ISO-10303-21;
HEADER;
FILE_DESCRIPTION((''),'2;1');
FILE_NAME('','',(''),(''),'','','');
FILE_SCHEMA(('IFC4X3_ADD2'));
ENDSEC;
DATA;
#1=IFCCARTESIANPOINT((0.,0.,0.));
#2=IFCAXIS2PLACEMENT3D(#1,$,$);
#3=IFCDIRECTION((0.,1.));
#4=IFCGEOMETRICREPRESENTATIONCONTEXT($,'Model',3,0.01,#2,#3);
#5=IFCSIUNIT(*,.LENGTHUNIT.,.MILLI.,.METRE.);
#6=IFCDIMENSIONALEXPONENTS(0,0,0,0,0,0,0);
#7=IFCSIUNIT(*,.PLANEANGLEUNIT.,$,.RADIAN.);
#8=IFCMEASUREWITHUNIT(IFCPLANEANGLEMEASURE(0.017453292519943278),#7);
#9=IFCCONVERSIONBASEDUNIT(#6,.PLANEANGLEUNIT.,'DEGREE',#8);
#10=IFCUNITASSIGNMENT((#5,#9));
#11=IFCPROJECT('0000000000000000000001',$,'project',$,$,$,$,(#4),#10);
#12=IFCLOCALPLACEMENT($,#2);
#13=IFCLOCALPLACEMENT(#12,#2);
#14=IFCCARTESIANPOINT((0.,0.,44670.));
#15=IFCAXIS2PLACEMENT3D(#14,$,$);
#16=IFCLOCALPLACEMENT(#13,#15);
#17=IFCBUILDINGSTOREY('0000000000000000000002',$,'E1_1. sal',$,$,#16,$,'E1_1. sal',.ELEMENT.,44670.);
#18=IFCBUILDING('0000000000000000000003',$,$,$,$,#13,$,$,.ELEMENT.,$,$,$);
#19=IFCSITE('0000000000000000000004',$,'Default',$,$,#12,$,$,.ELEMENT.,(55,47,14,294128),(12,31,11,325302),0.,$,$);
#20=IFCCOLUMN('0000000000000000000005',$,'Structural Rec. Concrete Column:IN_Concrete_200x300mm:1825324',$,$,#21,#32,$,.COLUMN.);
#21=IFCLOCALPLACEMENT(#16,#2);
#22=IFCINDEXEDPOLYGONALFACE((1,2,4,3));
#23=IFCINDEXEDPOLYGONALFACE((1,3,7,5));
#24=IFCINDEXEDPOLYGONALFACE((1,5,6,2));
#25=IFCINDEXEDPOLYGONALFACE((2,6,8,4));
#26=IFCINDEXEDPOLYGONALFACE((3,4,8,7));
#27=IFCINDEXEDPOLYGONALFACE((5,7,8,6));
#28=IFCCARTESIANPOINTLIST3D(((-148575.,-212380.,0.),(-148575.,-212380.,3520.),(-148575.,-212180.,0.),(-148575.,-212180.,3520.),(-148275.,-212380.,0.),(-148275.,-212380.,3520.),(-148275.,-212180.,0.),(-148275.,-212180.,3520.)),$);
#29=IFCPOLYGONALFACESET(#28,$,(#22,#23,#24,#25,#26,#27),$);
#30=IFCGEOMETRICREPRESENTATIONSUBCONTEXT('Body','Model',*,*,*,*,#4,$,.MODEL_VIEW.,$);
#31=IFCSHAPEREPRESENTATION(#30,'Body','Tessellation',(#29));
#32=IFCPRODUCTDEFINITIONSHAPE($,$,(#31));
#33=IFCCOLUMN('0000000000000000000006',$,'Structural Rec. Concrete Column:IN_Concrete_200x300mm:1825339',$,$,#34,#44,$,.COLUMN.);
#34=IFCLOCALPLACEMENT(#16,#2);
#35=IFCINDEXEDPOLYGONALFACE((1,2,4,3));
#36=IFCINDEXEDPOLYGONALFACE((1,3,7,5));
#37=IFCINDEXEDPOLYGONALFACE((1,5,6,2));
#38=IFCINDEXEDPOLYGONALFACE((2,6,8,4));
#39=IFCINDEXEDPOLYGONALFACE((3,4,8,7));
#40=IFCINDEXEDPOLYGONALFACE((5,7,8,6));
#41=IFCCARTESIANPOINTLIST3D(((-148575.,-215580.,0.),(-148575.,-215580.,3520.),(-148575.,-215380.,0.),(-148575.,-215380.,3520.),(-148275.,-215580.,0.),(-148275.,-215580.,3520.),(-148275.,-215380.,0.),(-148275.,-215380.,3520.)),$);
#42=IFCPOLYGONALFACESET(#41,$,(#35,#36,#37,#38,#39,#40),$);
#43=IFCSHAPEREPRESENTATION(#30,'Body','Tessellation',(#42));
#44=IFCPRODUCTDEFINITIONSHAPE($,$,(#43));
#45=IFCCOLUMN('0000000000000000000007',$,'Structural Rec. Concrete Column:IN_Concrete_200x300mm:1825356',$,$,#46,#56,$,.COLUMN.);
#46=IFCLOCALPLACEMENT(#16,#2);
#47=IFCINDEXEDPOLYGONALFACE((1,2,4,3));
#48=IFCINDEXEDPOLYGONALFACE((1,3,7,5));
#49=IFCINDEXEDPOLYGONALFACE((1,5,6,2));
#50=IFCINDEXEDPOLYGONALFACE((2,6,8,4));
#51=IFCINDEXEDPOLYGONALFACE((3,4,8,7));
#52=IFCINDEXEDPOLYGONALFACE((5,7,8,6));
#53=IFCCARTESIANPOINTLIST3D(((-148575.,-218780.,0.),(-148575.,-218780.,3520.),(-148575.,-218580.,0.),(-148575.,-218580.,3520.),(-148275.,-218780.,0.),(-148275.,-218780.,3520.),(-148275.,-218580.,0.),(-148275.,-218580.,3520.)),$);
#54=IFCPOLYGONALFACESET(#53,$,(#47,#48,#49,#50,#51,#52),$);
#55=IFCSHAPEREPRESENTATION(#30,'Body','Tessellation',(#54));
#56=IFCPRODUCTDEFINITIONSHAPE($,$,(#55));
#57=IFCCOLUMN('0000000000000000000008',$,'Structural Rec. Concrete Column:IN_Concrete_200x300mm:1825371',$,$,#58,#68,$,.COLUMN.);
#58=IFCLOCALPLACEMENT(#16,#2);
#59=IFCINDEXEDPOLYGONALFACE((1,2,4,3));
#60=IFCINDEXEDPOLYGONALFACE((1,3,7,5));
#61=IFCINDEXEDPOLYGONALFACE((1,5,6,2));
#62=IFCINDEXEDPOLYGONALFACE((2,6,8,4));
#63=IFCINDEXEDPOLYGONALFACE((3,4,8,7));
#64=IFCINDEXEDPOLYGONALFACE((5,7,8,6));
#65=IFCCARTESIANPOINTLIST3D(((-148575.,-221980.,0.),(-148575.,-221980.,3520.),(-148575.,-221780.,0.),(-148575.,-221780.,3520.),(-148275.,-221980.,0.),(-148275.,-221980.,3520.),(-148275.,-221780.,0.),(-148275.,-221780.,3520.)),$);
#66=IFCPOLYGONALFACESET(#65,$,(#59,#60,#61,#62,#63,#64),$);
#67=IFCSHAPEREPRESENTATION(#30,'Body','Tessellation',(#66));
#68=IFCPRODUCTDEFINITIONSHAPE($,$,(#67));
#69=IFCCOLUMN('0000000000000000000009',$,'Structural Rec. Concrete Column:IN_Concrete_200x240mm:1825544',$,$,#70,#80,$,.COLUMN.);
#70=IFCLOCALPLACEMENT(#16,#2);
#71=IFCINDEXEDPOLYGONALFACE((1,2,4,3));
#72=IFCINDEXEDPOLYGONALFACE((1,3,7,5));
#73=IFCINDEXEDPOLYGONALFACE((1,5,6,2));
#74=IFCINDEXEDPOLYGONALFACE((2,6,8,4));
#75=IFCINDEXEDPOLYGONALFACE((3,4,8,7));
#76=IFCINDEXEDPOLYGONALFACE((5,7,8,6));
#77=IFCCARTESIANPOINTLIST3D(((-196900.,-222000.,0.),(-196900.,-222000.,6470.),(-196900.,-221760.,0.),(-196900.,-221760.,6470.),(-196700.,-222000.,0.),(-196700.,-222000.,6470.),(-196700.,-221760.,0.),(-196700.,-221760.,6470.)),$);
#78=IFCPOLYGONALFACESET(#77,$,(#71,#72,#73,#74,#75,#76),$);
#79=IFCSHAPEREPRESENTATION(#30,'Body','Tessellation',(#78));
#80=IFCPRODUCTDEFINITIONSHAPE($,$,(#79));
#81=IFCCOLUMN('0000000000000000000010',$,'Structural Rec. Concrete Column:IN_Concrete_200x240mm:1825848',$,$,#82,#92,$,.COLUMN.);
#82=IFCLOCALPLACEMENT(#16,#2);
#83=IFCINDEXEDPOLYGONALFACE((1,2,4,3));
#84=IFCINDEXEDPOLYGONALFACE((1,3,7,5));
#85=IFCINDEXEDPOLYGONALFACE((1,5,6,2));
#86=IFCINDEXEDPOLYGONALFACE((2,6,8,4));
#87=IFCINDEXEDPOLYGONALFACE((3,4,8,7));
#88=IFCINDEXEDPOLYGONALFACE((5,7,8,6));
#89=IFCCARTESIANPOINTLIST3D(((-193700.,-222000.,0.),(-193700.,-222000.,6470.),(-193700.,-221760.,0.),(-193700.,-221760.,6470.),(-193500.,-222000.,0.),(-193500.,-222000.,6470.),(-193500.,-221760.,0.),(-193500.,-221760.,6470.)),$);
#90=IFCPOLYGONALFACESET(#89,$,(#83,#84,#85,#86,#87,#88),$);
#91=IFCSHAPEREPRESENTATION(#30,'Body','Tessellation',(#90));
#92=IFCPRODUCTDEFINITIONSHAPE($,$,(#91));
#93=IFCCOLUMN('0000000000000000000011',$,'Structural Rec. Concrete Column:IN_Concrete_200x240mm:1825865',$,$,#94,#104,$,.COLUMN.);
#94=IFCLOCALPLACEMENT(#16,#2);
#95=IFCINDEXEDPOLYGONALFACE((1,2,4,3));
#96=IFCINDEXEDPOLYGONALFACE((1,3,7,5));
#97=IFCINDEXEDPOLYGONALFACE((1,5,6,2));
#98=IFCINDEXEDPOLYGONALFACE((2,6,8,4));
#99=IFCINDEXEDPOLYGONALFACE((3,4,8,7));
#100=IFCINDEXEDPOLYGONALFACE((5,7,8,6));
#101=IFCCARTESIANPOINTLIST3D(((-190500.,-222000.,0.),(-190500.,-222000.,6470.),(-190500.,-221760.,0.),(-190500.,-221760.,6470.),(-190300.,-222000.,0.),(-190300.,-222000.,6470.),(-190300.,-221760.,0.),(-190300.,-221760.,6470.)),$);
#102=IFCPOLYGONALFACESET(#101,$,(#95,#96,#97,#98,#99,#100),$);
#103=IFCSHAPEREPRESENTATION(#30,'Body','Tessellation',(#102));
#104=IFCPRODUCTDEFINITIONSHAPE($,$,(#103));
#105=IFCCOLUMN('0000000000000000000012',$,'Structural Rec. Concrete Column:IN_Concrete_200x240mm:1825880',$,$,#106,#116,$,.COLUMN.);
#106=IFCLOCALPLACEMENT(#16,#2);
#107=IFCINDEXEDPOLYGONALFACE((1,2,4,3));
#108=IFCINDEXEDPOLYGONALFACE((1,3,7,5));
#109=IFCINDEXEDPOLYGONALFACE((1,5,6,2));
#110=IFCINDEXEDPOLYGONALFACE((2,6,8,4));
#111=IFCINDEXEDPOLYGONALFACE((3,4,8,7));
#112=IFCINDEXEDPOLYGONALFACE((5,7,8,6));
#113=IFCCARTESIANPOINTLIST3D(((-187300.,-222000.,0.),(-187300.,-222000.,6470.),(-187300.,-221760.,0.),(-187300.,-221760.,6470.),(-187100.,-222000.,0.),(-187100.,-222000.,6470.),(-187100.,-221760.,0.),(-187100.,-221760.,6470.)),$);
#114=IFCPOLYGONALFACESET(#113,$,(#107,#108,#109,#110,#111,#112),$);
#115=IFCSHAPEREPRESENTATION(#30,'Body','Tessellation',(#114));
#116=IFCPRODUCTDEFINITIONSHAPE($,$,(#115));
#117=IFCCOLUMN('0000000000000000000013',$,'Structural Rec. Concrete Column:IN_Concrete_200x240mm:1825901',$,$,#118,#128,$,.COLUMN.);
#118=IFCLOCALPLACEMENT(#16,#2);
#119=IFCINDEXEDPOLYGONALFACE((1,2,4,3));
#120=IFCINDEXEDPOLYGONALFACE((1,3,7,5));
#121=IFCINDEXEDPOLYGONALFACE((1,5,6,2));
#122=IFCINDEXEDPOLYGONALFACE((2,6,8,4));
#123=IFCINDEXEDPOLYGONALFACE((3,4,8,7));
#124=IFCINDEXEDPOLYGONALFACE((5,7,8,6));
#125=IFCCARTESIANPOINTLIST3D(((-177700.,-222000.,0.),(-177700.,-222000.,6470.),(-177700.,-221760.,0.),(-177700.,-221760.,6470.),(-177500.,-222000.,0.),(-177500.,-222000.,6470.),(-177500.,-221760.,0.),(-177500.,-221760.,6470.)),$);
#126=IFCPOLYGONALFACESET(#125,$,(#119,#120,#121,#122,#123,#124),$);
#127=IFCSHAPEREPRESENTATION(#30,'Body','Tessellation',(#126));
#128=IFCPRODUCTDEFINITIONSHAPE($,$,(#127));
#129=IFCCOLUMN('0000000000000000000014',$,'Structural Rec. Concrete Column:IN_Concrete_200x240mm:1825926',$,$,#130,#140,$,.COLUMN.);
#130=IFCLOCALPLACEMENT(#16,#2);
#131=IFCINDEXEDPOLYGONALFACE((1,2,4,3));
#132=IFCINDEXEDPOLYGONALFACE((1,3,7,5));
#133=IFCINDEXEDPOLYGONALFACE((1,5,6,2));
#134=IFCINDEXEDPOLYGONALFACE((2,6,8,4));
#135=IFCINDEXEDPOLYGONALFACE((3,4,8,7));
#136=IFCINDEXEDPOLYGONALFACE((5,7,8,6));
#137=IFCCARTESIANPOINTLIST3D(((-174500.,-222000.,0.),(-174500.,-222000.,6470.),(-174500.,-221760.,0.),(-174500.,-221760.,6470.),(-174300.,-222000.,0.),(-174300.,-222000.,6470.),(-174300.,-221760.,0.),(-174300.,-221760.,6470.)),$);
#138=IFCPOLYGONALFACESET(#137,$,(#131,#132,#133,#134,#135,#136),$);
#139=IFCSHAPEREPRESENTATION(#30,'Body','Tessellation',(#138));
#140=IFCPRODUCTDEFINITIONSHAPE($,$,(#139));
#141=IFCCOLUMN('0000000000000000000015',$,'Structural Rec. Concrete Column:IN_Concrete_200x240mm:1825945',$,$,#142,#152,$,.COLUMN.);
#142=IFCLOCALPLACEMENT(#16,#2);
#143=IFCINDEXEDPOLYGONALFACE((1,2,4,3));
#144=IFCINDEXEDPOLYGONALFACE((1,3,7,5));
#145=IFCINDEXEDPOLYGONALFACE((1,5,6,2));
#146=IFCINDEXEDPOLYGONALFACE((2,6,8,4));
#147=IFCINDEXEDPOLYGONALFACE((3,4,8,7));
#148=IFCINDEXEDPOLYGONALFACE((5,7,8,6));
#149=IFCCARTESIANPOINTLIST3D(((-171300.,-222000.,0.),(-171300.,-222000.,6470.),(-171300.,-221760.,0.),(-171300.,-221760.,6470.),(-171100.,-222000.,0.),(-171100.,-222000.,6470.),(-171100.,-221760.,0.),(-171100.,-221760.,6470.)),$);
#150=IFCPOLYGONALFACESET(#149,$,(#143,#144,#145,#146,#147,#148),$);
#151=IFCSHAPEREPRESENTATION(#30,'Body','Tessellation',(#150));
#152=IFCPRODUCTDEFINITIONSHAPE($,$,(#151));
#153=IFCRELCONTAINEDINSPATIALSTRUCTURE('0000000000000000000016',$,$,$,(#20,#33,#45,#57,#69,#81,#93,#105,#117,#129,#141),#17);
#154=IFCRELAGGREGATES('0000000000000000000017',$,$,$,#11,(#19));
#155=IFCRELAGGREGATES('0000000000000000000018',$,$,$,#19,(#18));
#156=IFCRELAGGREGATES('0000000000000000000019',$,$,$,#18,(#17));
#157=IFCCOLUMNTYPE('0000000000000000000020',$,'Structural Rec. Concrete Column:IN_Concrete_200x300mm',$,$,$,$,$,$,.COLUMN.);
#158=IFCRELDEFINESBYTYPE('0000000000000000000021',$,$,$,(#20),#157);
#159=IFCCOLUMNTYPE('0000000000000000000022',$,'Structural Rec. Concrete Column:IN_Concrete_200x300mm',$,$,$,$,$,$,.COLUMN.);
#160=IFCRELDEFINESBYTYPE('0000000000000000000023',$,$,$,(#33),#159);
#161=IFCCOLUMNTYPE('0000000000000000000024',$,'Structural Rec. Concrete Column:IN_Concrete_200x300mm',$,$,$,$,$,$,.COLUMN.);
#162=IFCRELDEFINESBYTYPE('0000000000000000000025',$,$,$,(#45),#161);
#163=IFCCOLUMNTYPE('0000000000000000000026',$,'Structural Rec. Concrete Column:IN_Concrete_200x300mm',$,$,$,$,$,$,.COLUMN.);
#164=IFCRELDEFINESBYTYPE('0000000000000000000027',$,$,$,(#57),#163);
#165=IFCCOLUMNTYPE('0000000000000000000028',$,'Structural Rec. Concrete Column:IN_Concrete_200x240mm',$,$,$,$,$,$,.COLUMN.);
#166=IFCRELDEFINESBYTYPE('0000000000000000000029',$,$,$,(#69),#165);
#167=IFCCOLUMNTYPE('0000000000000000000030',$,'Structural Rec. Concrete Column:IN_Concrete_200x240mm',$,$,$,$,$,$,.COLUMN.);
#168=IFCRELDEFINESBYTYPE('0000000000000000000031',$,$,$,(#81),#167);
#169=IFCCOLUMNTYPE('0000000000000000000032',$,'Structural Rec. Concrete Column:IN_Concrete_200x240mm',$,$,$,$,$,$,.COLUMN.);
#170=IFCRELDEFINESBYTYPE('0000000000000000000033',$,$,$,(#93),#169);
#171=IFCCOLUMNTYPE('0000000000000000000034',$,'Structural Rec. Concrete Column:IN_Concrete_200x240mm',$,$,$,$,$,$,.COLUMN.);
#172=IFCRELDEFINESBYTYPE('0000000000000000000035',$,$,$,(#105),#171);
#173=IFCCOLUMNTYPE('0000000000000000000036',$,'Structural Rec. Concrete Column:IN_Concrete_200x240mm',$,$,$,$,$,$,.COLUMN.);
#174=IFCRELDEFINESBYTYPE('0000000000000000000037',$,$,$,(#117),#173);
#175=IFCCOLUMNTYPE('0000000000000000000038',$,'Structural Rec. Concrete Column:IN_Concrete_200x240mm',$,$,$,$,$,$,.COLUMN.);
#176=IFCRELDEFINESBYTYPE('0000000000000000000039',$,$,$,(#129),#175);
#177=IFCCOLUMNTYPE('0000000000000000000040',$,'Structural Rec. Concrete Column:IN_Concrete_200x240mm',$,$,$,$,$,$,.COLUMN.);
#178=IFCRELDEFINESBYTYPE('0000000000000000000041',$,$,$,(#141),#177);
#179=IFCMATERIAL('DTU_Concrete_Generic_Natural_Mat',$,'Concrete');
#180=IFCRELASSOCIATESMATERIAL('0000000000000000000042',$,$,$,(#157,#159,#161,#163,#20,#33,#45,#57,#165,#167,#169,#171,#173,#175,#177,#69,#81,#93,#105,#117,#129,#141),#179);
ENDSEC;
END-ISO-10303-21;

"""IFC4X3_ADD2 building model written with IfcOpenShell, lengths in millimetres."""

from ifc_helpers import new_model, entity, si_unit, converted_unit, direction, frame, frame_2d, origin, place, context, subcontext, project, spatial, rectangle, extrude, source, transform, mapped, material, material_profile, profile_set, profile_usage, type_object, type_shapes, element, save


model = new_model("IFC4X3_ADD2")

# Units and contexts
model_context = context("Model", 3, precision=0.01, world=origin(), true_north=direction((0.0, 1.0)))
body_context = subcontext(model_context, "Body", "Model", "MODEL_VIEW")
ifc_project = project(units=[si_unit("LENGTHUNIT", "METRE", prefix="MILLI"), converted_unit("PLANEANGLEUNIT", "DEGREE", entity("IfcPlaneAngleMeasure", 0.017453292519943278), si_unit("PLANEANGLEUNIT", "RADIAN"), dimensions=[0, 0, 0, 0, 0, 0, 0])], contexts=[model_context])

# Site, building, storey
site_placement = place(None, origin())
site = spatial("IfcSite", under=ifc_project, at=site_placement, Name="Default", CompositionType="ELEMENT", RefLatitude=(55, 47, 14, 294128), RefLongitude=(12, 31, 11, 325302), RefElevation=0.0)
building_placement = place(site_placement, origin())
building = spatial("IfcBuilding", under=site, at=building_placement, CompositionType="ELEMENT")
storey_placement = place(building_placement, frame((0.0, 0.0, 44670.0)))
storey = spatial("IfcBuildingStorey", under=building, at=storey_placement, Name="E1_1. sal", LongName="E1_1. sal", CompositionType="ELEMENT", Elevation=44670.0)

# Columns
ifc_material = material(Name="DTU_Concrete_Generic_Natural_Mat", Category="Concrete")
ifc_material_profile_1 = material_profile(ifc_material, rectangle(XDim=200.0, YDim=300.0, at=frame_2d((0.0, 0.0), x_axis=(1.0, 0.0))), Name="IN_Concrete_200x300mm")
ifc_profile_set_1 = profile_set([ifc_material_profile_1], Name="IN_Concrete_200x300mm")
ifc_profile_usage_1 = profile_usage(ifc_profile_set_1)
column_type_1 = type_object("IfcColumnType", Name="Structural Rec. Concrete Column:IN_Concrete_200x300mm", PredefinedType="COLUMN", material=ifc_profile_set_1)
shared_shape_1 = source(origin(), body_context, "Body", "SweptSolid", [
    extrude(rectangle(XDim=200.0, YDim=300.0, at=frame_2d((0.0, 0.0), x_axis=(1.0, 0.0))), frame((-148425.0, -212280.0, 44670.0), z_axis=(0.0, 0.0, 1.0), x_axis=(0.0, -1.0, 0.0)), (0.0, 0.0, 1.0), 3520.0),
])
type_shapes(column_type_1, [shared_shape_1])
column_1_placement = place(storey_placement, frame((0.0, 0.0, -44670.0)))
element("IfcColumn", 1, at=column_1_placement, inside=storey, type_object=column_type_1, material=ifc_profile_usage_1, Name="Structural Rec. Concrete Column:IN_Concrete_200x300mm:1825324", PredefinedType="COLUMN", context=body_context, shape_type="MappedRepresentation", body=[
    mapped(shared_shape_1, transform((0.0, 0.0, 0.0), scale=1.0)),
])
column_type_2 = type_object("IfcColumnType", Name="Structural Rec. Concrete Column:IN_Concrete_200x300mm", PredefinedType="COLUMN", material=ifc_profile_set_1)
shared_shape_2 = source(origin(), body_context, "Body", "SweptSolid", [
    extrude(rectangle(XDim=200.0, YDim=300.0, at=frame_2d((0.0, 0.0), x_axis=(1.0, 0.0))), frame((-148425.0, -215480.0, 44670.0), z_axis=(0.0, 0.0, 1.0), x_axis=(0.0, -1.0, 0.0)), (0.0, 0.0, 1.0), 3520.0),
])
type_shapes(column_type_2, [shared_shape_2])
column_2_placement = place(storey_placement, frame((0.0, 0.0, -44670.0)))
element("IfcColumn", 2, at=column_2_placement, inside=storey, type_object=column_type_2, material=ifc_profile_usage_1, Name="Structural Rec. Concrete Column:IN_Concrete_200x300mm:1825339", PredefinedType="COLUMN", context=body_context, shape_type="MappedRepresentation", body=[
    mapped(shared_shape_2, transform((0.0, 0.0, 0.0), scale=1.0)),
])
column_type_3 = type_object("IfcColumnType", Name="Structural Rec. Concrete Column:IN_Concrete_200x300mm", PredefinedType="COLUMN", material=ifc_profile_set_1)
shared_shape_3 = source(origin(), body_context, "Body", "SweptSolid", [
    extrude(rectangle(XDim=200.0, YDim=300.0, at=frame_2d((0.0, 0.0), x_axis=(1.0, 0.0))), frame((-148425.0, -218680.0, 44670.0), z_axis=(0.0, 0.0, 1.0), x_axis=(0.0, -1.0, 0.0)), (0.0, 0.0, 1.0), 3520.0),
])
type_shapes(column_type_3, [shared_shape_3])
column_3_placement = place(storey_placement, frame((0.0, 0.0, -44670.0)))
element("IfcColumn", 3, at=column_3_placement, inside=storey, type_object=column_type_3, material=ifc_profile_usage_1, Name="Structural Rec. Concrete Column:IN_Concrete_200x300mm:1825356", PredefinedType="COLUMN", context=body_context, shape_type="MappedRepresentation", body=[
    mapped(shared_shape_3, transform((0.0, 0.0, 0.0), scale=1.0)),
])
column_type_4 = type_object("IfcColumnType", Name="Structural Rec. Concrete Column:IN_Concrete_200x300mm", PredefinedType="COLUMN", material=ifc_profile_set_1)
shared_shape_4 = source(origin(), body_context, "Body", "SweptSolid", [
    extrude(rectangle(XDim=200.0, YDim=300.0, at=frame_2d((0.0, 0.0), x_axis=(1.0, 0.0))), frame((-148425.0, -221880.0, 44670.0), z_axis=(0.0, 0.0, 1.0), x_axis=(0.0, -1.0, 0.0)), (0.0, 0.0, 1.0), 3520.0),
])
type_shapes(column_type_4, [shared_shape_4])
column_4_placement = place(storey_placement, frame((0.0, 0.0, -44670.0)))
element("IfcColumn", 4, at=column_4_placement, inside=storey, type_object=column_type_4, material=ifc_profile_usage_1, Name="Structural Rec. Concrete Column:IN_Concrete_200x300mm:1825371", PredefinedType="COLUMN", context=body_context, shape_type="MappedRepresentation", body=[
    mapped(shared_shape_4, transform((0.0, 0.0, 0.0), scale=1.0)),
])
ifc_material_profile_2 = material_profile(ifc_material, rectangle(XDim=200.0, YDim=240.0, at=frame_2d((0.0, 0.0), x_axis=(1.0, 0.0))), Name="IN_Concrete_200x240mm")
ifc_profile_set_2 = profile_set([ifc_material_profile_2], Name="IN_Concrete_200x240mm")
ifc_profile_usage_2 = profile_usage(ifc_profile_set_2)
column_type_5 = type_object("IfcColumnType", Name="Structural Rec. Concrete Column:IN_Concrete_200x240mm", PredefinedType="COLUMN", material=ifc_profile_set_2)
shared_shape_5 = source(origin(), body_context, "Body", "SweptSolid", [
    extrude(rectangle(XDim=200.0, YDim=240.0, at=frame_2d((0.0, 0.0), x_axis=(1.0, 0.0))), frame((-196800.0, -221880.0, 44670.0), z_axis=(0.0, 0.0, 1.0), x_axis=(-1.0, 0.0, 0.0)), (0.0, 0.0, 1.0), 6470.0),
])
type_shapes(column_type_5, [shared_shape_5])
column_5_placement = place(storey_placement, frame((0.0, 0.0, -44670.0)))
element("IfcColumn", 5, at=column_5_placement, inside=storey, type_object=column_type_5, material=ifc_profile_usage_2, Name="Structural Rec. Concrete Column:IN_Concrete_200x240mm:1825544", PredefinedType="COLUMN", context=body_context, shape_type="MappedRepresentation", body=[
    mapped(shared_shape_5, transform((0.0, 0.0, 0.0), scale=1.0)),
])
column_type_6 = type_object("IfcColumnType", Name="Structural Rec. Concrete Column:IN_Concrete_200x240mm", PredefinedType="COLUMN", material=ifc_profile_set_2)
shared_shape_6 = source(origin(), body_context, "Body", "SweptSolid", [
    extrude(rectangle(XDim=200.0, YDim=240.0, at=frame_2d((0.0, 0.0), x_axis=(1.0, 0.0))), frame((-193600.0, -221880.0, 44670.0), z_axis=(0.0, 0.0, 1.0), x_axis=(-1.0, 0.0, 0.0)), (0.0, 0.0, 1.0), 6470.0),
])
type_shapes(column_type_6, [shared_shape_6])
column_6_placement = place(storey_placement, frame((0.0, 0.0, -44670.0)))
element("IfcColumn", 6, at=column_6_placement, inside=storey, type_object=column_type_6, material=ifc_profile_usage_2, Name="Structural Rec. Concrete Column:IN_Concrete_200x240mm:1825848", PredefinedType="COLUMN", context=body_context, shape_type="MappedRepresentation", body=[
    mapped(shared_shape_6, transform((0.0, 0.0, 0.0), scale=1.0)),
])
column_type_7 = type_object("IfcColumnType", Name="Structural Rec. Concrete Column:IN_Concrete_200x240mm", PredefinedType="COLUMN", material=ifc_profile_set_2)
shared_shape_7 = source(origin(), body_context, "Body", "SweptSolid", [
    extrude(rectangle(XDim=200.0, YDim=240.0, at=frame_2d((0.0, 0.0), x_axis=(1.0, 0.0))), frame((-190400.0, -221880.0, 44670.0), z_axis=(0.0, 0.0, 1.0), x_axis=(-1.0, 0.0, 0.0)), (0.0, 0.0, 1.0), 6470.0),
])
type_shapes(column_type_7, [shared_shape_7])
column_7_placement = place(storey_placement, frame((0.0, 0.0, -44670.0)))
element("IfcColumn", 7, at=column_7_placement, inside=storey, type_object=column_type_7, material=ifc_profile_usage_2, Name="Structural Rec. Concrete Column:IN_Concrete_200x240mm:1825865", PredefinedType="COLUMN", context=body_context, shape_type="MappedRepresentation", body=[
    mapped(shared_shape_7, transform((0.0, 0.0, 0.0), scale=1.0)),
])
column_type_8 = type_object("IfcColumnType", Name="Structural Rec. Concrete Column:IN_Concrete_200x240mm", PredefinedType="COLUMN", material=ifc_profile_set_2)
shared_shape_8 = source(origin(), body_context, "Body", "SweptSolid", [
    extrude(rectangle(XDim=200.0, YDim=240.0, at=frame_2d((0.0, 0.0), x_axis=(1.0, 0.0))), frame((-187200.0, -221880.0, 44670.0), z_axis=(0.0, 0.0, 1.0), x_axis=(-1.0, 0.0, 0.0)), (0.0, 0.0, 1.0), 6470.0),
])
type_shapes(column_type_8, [shared_shape_8])
column_8_placement = place(storey_placement, frame((0.0, 0.0, -44670.0)))
element("IfcColumn", 8, at=column_8_placement, inside=storey, type_object=column_type_8, material=ifc_profile_usage_2, Name="Structural Rec. Concrete Column:IN_Concrete_200x240mm:1825880", PredefinedType="COLUMN", context=body_context, shape_type="MappedRepresentation", body=[
    mapped(shared_shape_8, transform((0.0, 0.0, 0.0), scale=1.0)),
])
column_type_9 = type_object("IfcColumnType", Name="Structural Rec. Concrete Column:IN_Concrete_200x240mm", PredefinedType="COLUMN", material=ifc_profile_set_2)
shared_shape_9 = source(origin(), body_context, "Body", "SweptSolid", [
    extrude(rectangle(XDim=200.0, YDim=240.0, at=frame_2d((0.0, 0.0), x_axis=(1.0, 0.0))), frame((-177600.0, -221880.0, 44670.0), z_axis=(0.0, 0.0, 1.0), x_axis=(-1.0, 0.0, 0.0)), (0.0, 0.0, 1.0), 6470.0),
])
type_shapes(column_type_9, [shared_shape_9])
column_9_placement = place(storey_placement, frame((0.0, 0.0, -44670.0)))
element("IfcColumn", 9, at=column_9_placement, inside=storey, type_object=column_type_9, material=ifc_profile_usage_2, Name="Structural Rec. Concrete Column:IN_Concrete_200x240mm:1825901", PredefinedType="COLUMN", context=body_context, shape_type="MappedRepresentation", body=[
    mapped(shared_shape_9, transform((0.0, 0.0, 0.0), scale=1.0)),
])
column_type_10 = type_object("IfcColumnType", Name="Structural Rec. Concrete Column:IN_Concrete_200x240mm", PredefinedType="COLUMN", material=ifc_profile_set_2)
shared_shape_10 = source(origin(), body_context, "Body", "SweptSolid", [
    extrude(rectangle(XDim=200.0, YDim=240.0, at=frame_2d((0.0, 0.0), x_axis=(1.0, 0.0))), frame((-174400.0, -221880.0, 44670.0), z_axis=(0.0, 0.0, 1.0), x_axis=(-1.0, 0.0, 0.0)), (0.0, 0.0, 1.0), 6470.0),
])
type_shapes(column_type_10, [shared_shape_10])
column_10_placement = place(storey_placement, frame((0.0, 0.0, -44670.0)))
element("IfcColumn", 10, at=column_10_placement, inside=storey, type_object=column_type_10, material=ifc_profile_usage_2, Name="Structural Rec. Concrete Column:IN_Concrete_200x240mm:1825926", PredefinedType="COLUMN", context=body_context, shape_type="MappedRepresentation", body=[
    mapped(shared_shape_10, transform((0.0, 0.0, 0.0), scale=1.0)),
])
column_type_11 = type_object("IfcColumnType", Name="Structural Rec. Concrete Column:IN_Concrete_200x240mm", PredefinedType="COLUMN", material=ifc_profile_set_2)
shared_shape_11 = source(origin(), body_context, "Body", "SweptSolid", [
    extrude(rectangle(XDim=200.0, YDim=240.0, at=frame_2d((0.0, 0.0), x_axis=(1.0, 0.0))), frame((-171200.0, -221880.0, 44670.0), z_axis=(0.0, 0.0, 1.0), x_axis=(-1.0, 0.0, 0.0)), (0.0, 0.0, 1.0), 6470.0),
])
type_shapes(column_type_11, [shared_shape_11])
column_11_placement = place(storey_placement, frame((0.0, 0.0, -44670.0)))
element("IfcColumn", 11, at=column_11_placement, inside=storey, type_object=column_type_11, material=ifc_profile_usage_2, Name="Structural Rec. Concrete Column:IN_Concrete_200x240mm:1825945", PredefinedType="COLUMN", context=body_context, shape_type="MappedRepresentation", body=[
    mapped(shared_shape_11, transform((0.0, 0.0, 0.0), scale=1.0)),
])

save(model, "model.ifc")
